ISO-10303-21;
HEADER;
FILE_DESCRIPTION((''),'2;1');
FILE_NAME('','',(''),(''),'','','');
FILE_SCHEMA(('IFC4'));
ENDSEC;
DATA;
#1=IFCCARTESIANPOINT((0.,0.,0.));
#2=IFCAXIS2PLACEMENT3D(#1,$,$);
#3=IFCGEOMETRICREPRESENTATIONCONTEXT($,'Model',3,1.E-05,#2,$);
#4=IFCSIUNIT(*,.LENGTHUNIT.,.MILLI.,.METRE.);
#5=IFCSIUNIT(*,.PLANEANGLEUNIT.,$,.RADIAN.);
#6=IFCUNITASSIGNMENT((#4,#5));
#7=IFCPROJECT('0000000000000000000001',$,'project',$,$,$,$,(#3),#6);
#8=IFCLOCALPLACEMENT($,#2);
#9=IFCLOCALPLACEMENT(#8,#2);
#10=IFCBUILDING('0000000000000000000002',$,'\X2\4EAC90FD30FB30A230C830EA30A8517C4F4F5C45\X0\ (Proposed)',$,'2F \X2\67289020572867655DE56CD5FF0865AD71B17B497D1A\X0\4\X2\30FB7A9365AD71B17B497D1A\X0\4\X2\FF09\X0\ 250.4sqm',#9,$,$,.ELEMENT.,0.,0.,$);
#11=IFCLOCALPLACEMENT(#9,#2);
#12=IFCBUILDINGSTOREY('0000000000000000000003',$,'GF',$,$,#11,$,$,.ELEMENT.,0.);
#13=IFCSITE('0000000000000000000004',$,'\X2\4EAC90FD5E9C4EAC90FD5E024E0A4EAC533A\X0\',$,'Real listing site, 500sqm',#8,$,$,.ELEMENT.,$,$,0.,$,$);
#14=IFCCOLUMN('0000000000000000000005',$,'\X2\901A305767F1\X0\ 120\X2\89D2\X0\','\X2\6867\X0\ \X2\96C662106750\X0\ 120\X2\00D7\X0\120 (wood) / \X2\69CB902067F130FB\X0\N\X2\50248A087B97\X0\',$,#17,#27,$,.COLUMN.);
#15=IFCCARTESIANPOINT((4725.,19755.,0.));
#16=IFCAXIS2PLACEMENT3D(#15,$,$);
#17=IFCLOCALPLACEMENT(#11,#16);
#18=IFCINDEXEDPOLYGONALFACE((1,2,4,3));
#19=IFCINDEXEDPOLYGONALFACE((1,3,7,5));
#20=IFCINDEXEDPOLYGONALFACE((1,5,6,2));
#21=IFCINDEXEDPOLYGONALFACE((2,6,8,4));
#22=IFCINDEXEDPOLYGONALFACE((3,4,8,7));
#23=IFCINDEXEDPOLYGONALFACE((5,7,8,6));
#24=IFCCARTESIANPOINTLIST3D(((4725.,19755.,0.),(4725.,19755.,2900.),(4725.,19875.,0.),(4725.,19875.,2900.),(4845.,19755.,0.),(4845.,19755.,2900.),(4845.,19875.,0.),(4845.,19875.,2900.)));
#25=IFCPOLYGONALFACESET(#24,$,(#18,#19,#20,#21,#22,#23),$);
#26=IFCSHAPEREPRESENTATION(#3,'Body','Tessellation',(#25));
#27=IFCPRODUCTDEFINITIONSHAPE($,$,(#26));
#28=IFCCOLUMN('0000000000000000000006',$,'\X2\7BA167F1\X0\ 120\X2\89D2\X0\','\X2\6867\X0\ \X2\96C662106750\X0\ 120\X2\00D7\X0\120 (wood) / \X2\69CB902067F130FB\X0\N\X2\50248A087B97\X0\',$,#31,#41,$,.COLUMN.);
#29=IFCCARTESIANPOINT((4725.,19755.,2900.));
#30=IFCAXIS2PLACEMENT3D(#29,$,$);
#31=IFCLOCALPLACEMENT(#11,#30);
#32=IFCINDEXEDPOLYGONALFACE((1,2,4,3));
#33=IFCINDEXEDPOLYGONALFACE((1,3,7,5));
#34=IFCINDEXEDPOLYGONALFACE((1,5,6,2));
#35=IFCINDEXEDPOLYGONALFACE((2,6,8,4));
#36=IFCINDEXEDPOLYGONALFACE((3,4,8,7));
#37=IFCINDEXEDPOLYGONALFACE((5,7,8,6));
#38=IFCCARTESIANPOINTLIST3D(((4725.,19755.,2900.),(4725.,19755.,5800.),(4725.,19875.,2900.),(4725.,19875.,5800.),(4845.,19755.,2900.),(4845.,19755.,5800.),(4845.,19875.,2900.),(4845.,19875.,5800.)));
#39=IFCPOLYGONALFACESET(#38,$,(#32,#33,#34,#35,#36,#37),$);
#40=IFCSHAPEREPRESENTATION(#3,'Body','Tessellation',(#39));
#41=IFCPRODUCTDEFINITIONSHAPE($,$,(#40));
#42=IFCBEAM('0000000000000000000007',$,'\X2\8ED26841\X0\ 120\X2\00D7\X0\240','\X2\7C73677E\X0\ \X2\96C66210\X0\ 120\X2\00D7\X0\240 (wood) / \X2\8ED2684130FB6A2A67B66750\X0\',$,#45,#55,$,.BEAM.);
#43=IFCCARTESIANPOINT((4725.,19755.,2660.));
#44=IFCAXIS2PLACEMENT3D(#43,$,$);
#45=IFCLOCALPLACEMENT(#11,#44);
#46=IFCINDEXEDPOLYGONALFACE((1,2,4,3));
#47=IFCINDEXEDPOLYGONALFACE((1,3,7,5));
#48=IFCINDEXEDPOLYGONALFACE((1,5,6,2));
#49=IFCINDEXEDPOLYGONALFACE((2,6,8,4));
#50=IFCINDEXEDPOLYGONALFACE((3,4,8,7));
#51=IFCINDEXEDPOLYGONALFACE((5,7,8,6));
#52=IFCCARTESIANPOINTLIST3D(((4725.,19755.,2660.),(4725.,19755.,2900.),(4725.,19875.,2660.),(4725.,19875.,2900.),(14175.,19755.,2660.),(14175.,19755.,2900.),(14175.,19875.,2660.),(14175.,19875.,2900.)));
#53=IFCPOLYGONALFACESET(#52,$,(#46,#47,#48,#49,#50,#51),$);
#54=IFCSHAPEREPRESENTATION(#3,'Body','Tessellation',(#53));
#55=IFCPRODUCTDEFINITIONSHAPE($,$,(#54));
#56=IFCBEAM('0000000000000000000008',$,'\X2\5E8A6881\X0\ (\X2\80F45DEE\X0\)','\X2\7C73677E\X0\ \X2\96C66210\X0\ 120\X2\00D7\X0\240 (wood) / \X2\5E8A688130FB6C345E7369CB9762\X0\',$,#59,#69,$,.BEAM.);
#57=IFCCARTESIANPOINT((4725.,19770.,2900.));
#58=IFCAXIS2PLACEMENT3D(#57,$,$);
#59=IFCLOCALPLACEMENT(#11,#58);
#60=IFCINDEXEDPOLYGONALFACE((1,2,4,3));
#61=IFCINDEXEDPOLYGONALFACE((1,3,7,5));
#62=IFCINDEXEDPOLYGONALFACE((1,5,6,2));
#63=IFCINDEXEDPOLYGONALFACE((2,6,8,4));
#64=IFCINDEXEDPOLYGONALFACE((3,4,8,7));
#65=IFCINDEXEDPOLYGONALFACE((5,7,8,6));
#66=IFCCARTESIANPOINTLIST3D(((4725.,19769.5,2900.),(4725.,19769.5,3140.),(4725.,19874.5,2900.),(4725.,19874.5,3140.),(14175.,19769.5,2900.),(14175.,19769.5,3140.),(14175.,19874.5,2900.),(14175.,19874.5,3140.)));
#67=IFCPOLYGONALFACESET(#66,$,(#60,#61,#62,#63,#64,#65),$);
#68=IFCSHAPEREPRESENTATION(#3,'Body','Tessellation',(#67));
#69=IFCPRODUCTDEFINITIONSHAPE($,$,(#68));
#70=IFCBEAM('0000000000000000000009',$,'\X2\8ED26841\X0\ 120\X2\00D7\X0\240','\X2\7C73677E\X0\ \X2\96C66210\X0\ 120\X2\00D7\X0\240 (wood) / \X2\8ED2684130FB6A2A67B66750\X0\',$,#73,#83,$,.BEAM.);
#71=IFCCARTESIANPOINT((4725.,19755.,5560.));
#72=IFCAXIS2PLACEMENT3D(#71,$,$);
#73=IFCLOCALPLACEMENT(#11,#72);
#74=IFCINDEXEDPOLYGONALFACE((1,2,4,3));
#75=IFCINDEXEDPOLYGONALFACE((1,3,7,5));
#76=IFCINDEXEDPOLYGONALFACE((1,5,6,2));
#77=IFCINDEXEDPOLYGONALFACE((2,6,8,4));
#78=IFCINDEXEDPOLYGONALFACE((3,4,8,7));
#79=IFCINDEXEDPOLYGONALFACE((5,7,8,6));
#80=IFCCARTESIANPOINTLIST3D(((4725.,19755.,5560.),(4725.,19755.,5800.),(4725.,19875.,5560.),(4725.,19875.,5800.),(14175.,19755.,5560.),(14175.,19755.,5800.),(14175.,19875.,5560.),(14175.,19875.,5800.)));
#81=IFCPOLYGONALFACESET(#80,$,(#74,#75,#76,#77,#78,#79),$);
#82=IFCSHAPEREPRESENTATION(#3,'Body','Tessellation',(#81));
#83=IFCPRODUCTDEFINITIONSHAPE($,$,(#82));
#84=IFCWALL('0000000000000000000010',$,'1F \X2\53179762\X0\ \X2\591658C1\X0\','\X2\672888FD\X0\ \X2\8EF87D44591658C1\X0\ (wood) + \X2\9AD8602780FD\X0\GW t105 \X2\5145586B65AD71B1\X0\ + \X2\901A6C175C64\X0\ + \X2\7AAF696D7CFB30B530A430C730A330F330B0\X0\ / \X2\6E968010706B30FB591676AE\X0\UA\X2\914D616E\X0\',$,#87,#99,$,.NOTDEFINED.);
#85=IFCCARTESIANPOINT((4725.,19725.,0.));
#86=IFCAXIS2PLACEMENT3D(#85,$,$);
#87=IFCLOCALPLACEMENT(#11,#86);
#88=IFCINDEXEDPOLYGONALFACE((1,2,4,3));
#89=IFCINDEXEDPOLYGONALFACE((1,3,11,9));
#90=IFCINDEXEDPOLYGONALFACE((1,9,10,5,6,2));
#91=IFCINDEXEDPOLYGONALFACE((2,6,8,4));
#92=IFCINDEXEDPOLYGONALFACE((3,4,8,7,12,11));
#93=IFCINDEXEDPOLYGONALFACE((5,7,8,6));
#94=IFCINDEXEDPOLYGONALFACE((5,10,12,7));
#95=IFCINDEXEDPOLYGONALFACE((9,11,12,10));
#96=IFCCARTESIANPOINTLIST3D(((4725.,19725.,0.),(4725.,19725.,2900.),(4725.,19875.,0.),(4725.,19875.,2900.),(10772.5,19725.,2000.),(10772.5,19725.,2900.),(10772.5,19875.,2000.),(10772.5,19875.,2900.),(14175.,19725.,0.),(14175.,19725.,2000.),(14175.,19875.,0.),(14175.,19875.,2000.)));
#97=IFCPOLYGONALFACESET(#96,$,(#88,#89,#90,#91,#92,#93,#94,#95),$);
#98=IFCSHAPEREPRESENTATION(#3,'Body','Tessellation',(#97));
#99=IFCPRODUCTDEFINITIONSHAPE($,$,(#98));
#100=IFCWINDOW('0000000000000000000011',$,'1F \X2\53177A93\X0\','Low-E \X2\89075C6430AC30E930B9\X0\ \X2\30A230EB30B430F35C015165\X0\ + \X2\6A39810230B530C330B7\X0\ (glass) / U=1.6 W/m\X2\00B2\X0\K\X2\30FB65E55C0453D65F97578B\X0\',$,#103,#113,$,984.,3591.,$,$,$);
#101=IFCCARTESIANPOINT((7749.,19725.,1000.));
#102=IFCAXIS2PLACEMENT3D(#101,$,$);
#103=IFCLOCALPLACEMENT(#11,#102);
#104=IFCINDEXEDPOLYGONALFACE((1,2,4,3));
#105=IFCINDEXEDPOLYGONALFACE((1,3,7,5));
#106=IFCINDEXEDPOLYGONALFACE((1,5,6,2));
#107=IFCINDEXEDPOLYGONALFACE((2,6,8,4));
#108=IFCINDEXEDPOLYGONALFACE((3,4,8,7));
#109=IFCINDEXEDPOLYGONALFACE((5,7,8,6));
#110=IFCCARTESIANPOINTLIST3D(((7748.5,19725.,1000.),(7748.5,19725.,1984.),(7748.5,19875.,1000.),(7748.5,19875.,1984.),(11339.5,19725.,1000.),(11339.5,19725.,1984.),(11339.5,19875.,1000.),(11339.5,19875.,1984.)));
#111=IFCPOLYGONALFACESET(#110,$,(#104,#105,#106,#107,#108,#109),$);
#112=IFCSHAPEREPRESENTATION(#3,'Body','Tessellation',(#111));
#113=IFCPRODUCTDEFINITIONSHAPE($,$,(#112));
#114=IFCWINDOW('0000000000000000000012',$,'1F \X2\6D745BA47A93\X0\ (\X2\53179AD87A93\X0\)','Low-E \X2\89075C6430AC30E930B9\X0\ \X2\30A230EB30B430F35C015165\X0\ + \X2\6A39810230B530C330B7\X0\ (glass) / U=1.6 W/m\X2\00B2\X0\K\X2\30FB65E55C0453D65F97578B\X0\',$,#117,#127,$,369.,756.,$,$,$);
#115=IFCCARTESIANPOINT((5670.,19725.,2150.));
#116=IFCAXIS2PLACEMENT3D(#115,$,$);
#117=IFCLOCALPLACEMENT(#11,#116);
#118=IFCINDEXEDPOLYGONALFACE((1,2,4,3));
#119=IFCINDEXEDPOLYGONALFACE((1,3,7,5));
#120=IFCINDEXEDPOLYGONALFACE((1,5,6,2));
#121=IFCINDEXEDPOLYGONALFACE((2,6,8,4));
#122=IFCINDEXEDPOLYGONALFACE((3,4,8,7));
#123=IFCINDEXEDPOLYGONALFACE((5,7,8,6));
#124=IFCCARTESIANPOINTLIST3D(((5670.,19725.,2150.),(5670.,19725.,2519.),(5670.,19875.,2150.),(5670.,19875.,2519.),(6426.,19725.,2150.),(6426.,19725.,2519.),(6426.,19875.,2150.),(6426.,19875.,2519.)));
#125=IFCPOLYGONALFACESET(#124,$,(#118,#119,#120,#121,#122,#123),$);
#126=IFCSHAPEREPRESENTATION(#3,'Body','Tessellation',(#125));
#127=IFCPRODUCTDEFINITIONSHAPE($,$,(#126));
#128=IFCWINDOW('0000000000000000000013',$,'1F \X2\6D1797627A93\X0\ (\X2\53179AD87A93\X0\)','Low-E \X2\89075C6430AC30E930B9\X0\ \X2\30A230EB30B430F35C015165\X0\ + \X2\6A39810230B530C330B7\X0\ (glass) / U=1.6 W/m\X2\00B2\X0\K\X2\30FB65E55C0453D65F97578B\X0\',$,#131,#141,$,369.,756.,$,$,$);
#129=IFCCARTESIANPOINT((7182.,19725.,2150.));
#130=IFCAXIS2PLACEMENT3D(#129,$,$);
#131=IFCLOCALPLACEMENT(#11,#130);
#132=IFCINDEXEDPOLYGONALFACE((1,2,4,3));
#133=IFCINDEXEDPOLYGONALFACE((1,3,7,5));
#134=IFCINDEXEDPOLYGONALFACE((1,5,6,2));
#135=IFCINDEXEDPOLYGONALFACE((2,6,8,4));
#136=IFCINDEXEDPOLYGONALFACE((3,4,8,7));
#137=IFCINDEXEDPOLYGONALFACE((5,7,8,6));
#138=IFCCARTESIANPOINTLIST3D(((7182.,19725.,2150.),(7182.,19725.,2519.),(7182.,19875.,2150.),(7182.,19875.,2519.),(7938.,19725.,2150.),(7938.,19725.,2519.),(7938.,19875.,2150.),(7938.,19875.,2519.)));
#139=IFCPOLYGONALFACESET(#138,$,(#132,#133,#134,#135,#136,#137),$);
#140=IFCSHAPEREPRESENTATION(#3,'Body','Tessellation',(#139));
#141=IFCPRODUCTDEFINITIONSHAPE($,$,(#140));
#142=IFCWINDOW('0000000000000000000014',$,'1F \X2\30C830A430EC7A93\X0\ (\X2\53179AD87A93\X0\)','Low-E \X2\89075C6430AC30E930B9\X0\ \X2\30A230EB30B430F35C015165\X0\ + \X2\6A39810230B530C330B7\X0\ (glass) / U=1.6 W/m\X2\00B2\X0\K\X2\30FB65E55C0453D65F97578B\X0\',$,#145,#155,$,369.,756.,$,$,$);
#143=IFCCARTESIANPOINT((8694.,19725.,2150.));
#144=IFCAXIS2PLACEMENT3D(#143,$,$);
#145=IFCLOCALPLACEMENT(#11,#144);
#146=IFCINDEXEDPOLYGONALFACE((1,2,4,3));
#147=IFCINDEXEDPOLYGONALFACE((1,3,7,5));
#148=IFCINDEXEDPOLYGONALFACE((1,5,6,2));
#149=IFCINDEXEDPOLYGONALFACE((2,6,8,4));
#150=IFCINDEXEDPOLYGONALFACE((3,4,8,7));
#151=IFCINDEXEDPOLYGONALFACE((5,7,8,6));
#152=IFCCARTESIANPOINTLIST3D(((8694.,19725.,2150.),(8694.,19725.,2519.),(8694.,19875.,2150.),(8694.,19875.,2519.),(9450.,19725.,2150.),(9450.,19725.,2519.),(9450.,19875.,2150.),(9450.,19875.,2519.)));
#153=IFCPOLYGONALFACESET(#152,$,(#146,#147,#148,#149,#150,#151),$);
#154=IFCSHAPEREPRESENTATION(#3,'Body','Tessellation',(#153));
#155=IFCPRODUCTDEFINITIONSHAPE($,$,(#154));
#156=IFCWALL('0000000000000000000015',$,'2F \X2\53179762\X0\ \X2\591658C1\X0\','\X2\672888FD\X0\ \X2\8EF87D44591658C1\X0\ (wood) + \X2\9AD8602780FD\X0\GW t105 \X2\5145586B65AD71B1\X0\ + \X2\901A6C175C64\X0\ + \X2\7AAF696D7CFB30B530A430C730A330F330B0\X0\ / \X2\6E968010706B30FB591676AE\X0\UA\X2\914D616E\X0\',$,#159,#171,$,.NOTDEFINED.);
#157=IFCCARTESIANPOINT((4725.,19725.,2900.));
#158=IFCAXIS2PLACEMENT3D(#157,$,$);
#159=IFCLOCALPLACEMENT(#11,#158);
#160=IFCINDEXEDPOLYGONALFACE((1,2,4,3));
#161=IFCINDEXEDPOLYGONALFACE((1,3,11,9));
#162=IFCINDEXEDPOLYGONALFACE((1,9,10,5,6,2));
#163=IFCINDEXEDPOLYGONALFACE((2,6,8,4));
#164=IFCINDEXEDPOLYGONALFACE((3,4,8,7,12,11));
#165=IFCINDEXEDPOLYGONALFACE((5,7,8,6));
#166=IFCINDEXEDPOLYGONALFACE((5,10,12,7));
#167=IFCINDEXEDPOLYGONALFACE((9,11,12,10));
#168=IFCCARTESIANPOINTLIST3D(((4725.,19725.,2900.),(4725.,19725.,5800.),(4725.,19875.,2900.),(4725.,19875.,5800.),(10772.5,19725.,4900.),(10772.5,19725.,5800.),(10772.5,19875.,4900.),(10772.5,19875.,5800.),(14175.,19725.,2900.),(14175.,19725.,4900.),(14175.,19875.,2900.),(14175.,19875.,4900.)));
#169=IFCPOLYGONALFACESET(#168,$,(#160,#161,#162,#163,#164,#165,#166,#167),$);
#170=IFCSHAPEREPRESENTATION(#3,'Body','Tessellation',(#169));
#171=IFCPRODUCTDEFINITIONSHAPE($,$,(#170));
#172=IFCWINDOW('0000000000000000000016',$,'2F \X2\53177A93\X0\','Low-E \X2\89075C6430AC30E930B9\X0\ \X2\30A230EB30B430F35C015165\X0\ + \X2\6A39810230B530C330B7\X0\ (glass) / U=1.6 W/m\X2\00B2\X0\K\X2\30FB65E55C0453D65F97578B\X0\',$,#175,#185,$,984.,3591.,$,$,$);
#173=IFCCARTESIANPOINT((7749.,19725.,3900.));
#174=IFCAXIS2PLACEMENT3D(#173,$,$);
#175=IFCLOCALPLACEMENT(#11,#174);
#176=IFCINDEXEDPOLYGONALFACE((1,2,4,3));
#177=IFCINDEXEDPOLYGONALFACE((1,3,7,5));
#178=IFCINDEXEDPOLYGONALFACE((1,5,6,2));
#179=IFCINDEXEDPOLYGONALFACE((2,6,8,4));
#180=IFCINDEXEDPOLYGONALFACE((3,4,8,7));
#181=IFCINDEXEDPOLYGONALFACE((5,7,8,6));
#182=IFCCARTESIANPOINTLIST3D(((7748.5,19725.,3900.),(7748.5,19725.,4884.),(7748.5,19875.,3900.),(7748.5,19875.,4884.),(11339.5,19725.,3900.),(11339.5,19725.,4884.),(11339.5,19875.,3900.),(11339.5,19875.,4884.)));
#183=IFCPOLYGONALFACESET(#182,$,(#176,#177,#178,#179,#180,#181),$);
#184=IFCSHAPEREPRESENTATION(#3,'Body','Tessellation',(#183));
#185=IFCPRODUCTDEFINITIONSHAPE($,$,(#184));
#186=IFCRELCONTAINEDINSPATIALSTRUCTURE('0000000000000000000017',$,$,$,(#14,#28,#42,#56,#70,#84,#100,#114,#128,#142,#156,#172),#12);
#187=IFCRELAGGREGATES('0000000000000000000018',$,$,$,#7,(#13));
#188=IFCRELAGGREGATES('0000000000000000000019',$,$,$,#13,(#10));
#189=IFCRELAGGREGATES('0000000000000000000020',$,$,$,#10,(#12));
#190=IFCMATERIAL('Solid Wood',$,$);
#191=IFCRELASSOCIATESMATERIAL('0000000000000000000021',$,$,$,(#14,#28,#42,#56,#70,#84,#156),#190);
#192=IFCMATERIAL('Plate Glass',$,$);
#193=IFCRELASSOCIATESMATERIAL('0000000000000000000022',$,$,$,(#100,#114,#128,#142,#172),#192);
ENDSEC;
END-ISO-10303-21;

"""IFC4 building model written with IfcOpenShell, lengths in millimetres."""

from ifc_helpers import new_model, si_unit, frame, frame_2d, origin, place, context, project, spatial, rectangle, extrude, material, element, fill, save


model = new_model("IFC4")

# Units and contexts
model_context = context("Model", 3, precision=1e-05, world=origin())
ifc_project = project(units=[si_unit("LENGTHUNIT", "METRE", prefix="MILLI"), si_unit("PLANEANGLEUNIT", "RADIAN")], contexts=[model_context])

# Site, building, storey
site_placement = place(None, origin())
site = spatial("IfcSite", under=ifc_project, at=site_placement, Name="京都府京都市上京区", ObjectType="Real listing site, 500sqm", CompositionType="ELEMENT", RefElevation=0.0)
building_placement = place(site_placement, origin())
building = spatial("IfcBuilding", under=site, at=building_placement, Name="京都・アトリエ兼住居 (Proposed)", ObjectType="2F 木造在来工法（断熱等級4・窓断熱等級4） 250.4sqm", CompositionType="ELEMENT", ElevationOfRefHeight=0.0, ElevationOfTerrain=0.0)
storey_placement = place(building_placement, origin())
storey = spatial("IfcBuildingStorey", under=building, at=storey_placement, Name="GF", CompositionType="ELEMENT", Elevation=0.0)

# Columns
ifc_material_1 = material(Name="Solid Wood")
column_1_placement = place(storey_placement, frame((4725.0, 19755.0, 0.0)))
element("IfcColumn", 1, at=column_1_placement, inside=storey, material=ifc_material_1, Name="通し柱 120角", Description="桧 集成材 120×120 (wood) / 構造柱・N値計算", PredefinedType="COLUMN", context=model_context, shape_type="SweptSolid", body=[
    extrude(rectangle(XDim=120.0, YDim=120.0, at=frame_2d((60.0, 60.0))), frame((4725.0, 19755.0, 0.0)), (0.0, 0.0, 1.0), 2900.0),
])
column_2_placement = place(storey_placement, frame((4725.0, 19755.0, 2900.0)))
element("IfcColumn", 2, at=column_2_placement, inside=storey, material=ifc_material_1, Name="管柱 120角", Description="桧 集成材 120×120 (wood) / 構造柱・N値計算", PredefinedType="COLUMN", context=model_context, shape_type="SweptSolid", body=[
    extrude(rectangle(XDim=120.0, YDim=120.0, at=frame_2d((60.0, 60.0))), frame((4725.0, 19755.0, 2900.0)), (0.0, 0.0, 1.0), 2900.0),
])

# Beams
beam_1_placement = place(storey_placement, frame((4725.0, 19755.0, 2660.0)))
element("IfcBeam", 3, at=beam_1_placement, inside=storey, material=ifc_material_1, Name="軒桁 120×240", Description="米松 集成 120×240 (wood) / 軒桁・横架材", PredefinedType="BEAM", context=model_context, shape_type="SweptSolid", body=[
    extrude(rectangle(XDim=9450.0, YDim=120.0, at=frame_2d((4725.0, 60.0))), frame((4725.0, 19755.0, 2660.0)), (0.0, 0.0, 1.0), 240.0),
])
beam_2_placement = place(storey_placement, frame((4725.0, 19770.0, 2900.0)))
element("IfcBeam", 4, at=beam_2_placement, inside=storey, material=ifc_material_1, Name="床梁 (胴差)", Description="米松 集成 120×240 (wood) / 床梁・水平構面", PredefinedType="BEAM", context=model_context, shape_type="SweptSolid", body=[
    extrude(rectangle(XDim=9450.0, YDim=105.0, at=frame_2d((4725.0, 52.0))), frame((4725.0, 19770.0, 2900.0)), (0.0, 0.0, 1.0), 240.0),
])
beam_3_placement = place(storey_placement, frame((4725.0, 19755.0, 5560.0)))
element("IfcBeam", 5, at=beam_3_placement, inside=storey, material=ifc_material_1, Name="軒桁 120×240", Description="米松 集成 120×240 (wood) / 軒桁・横架材", PredefinedType="BEAM", context=model_context, shape_type="SweptSolid", body=[
    extrude(rectangle(XDim=9450.0, YDim=120.0, at=frame_2d((4725.0, 60.0))), frame((4725.0, 19755.0, 5560.0)), (0.0, 0.0, 1.0), 240.0),
])

# Wall, openings, windows
wall_1_placement = place(storey_placement, frame((4725.0, 19725.0, 0.0)))
wall_1 = element("IfcWall", 6, at=wall_1_placement, inside=storey, material=ifc_material_1, Name="1F 北面 外壁", Description="木製 軸組外壁 (wood) + 高性能GW t105 充填断熱 + 通気層 + 窯業系サイディング / 準耐火・外皮UA配慮", PredefinedType="NOTDEFINED", context=model_context, shape_type="SweptSolid", body=[
    extrude(rectangle(XDim=9450.0, YDim=150.0, at=frame_2d((4725.0, 75.0))), frame((4725.0, 19725.0, 0.0)), (0.0, 0.0, 1.0), 2900.0),
])
opening_1_placement = place(storey_placement, frame((7749.0, 19725.0, 1000.0)))
opening_1 = element("IfcOpeningElement", 7, at=opening_1_placement, cuts=wall_1, PredefinedType="NOTDEFINED", context=model_context, shape_type="SweptSolid", body=[
    extrude(rectangle(XDim=3591.0, YDim=150.0, at=frame_2d((1795.0, 75.0))), frame((7749.0, 19725.0, 1000.0)), (0.0, 0.0, 1.0), 984.0),
])
opening_2_placement = place(storey_placement, frame((5670.0, 19725.0, 2150.0)))
opening_2 = element("IfcOpeningElement", 8, at=opening_2_placement, cuts=wall_1, PredefinedType="NOTDEFINED", context=model_context, shape_type="SweptSolid", body=[
    extrude(rectangle(XDim=756.0, YDim=150.0, at=frame_2d((378.0, 75.0))), frame((5670.0, 19725.0, 2150.0)), (0.0, 0.0, 1.0), 369.0),
])
opening_3_placement = place(storey_placement, frame((7182.0, 19725.0, 2150.0)))
opening_3 = element("IfcOpeningElement", 9, at=opening_3_placement, cuts=wall_1, PredefinedType="NOTDEFINED", context=model_context, shape_type="SweptSolid", body=[
    extrude(rectangle(XDim=756.0, YDim=150.0, at=frame_2d((378.0, 75.0))), frame((7182.0, 19725.0, 2150.0)), (0.0, 0.0, 1.0), 369.0),
])
opening_4_placement = place(storey_placement, frame((8694.0, 19725.0, 2150.0)))
opening_4 = element("IfcOpeningElement", 10, at=opening_4_placement, cuts=wall_1, PredefinedType="NOTDEFINED", context=model_context, shape_type="SweptSolid", body=[
    extrude(rectangle(XDim=756.0, YDim=150.0, at=frame_2d((378.0, 75.0))), frame((8694.0, 19725.0, 2150.0)), (0.0, 0.0, 1.0), 369.0),
])
ifc_material_2 = material(Name="Plate Glass")
window_1_placement = place(storey_placement, frame((7749.0, 19725.0, 1000.0)))
window_1 = element("IfcWindow", 11, at=window_1_placement, inside=storey, material=ifc_material_2, Name="1F 北窓", Description="Low-E 複層ガラス アルゴン封入 + 樹脂サッシ (glass) / U=1.6 W/m²K・日射取得型", OverallHeight=984.0, OverallWidth=3591.0, context=model_context, shape_type="SweptSolid", body=[
    extrude(rectangle(XDim=3591.0, YDim=150.0, at=frame_2d((1795.0, 75.0))), frame((7749.0, 19725.0, 1000.0)), (0.0, 0.0, 1.0), 984.0),
])
fill(opening_1, window_1)
window_2_placement = place(storey_placement, frame((5670.0, 19725.0, 2150.0)))
window_2 = element("IfcWindow", 12, at=window_2_placement, inside=storey, material=ifc_material_2, Name="1F 浴室窓 (北高窓)", Description="Low-E 複層ガラス アルゴン封入 + 樹脂サッシ (glass) / U=1.6 W/m²K・日射取得型", OverallHeight=369.0, OverallWidth=756.0, context=model_context, shape_type="SweptSolid", body=[
    extrude(rectangle(XDim=756.0, YDim=150.0, at=frame_2d((378.0, 75.0))), frame((5670.0, 19725.0, 2150.0)), (0.0, 0.0, 1.0), 369.0),
])
fill(opening_2, window_2)
window_3_placement = place(storey_placement, frame((7182.0, 19725.0, 2150.0)))
window_3 = element("IfcWindow", 13, at=window_3_placement, inside=storey, material=ifc_material_2, Name="1F 洗面窓 (北高窓)", Description="Low-E 複層ガラス アルゴン封入 + 樹脂サッシ (glass) / U=1.6 W/m²K・日射取得型", OverallHeight=369.0, OverallWidth=756.0, context=model_context, shape_type="SweptSolid", body=[
    extrude(rectangle(XDim=756.0, YDim=150.0, at=frame_2d((378.0, 75.0))), frame((7182.0, 19725.0, 2150.0)), (0.0, 0.0, 1.0), 369.0),
])
fill(opening_3, window_3)
window_4_placement = place(storey_placement, frame((8694.0, 19725.0, 2150.0)))
window_4 = element("IfcWindow", 14, at=window_4_placement, inside=storey, material=ifc_material_2, Name="1F トイレ窓 (北高窓)", Description="Low-E 複層ガラス アルゴン封入 + 樹脂サッシ (glass) / U=1.6 W/m²K・日射取得型", OverallHeight=369.0, OverallWidth=756.0, context=model_context, shape_type="SweptSolid", body=[
    extrude(rectangle(XDim=756.0, YDim=150.0, at=frame_2d((378.0, 75.0))), frame((8694.0, 19725.0, 2150.0)), (0.0, 0.0, 1.0), 369.0),
])
fill(opening_4, window_4)

# Wall, opening, window
wall_2_placement = place(storey_placement, frame((4725.0, 19725.0, 2900.0)))
wall_2 = element("IfcWall", 15, at=wall_2_placement, inside=storey, material=ifc_material_1, Name="2F 北面 外壁", Description="木製 軸組外壁 (wood) + 高性能GW t105 充填断熱 + 通気層 + 窯業系サイディング / 準耐火・外皮UA配慮", PredefinedType="NOTDEFINED", context=model_context, shape_type="SweptSolid", body=[
    extrude(rectangle(XDim=9450.0, YDim=150.0, at=frame_2d((4725.0, 75.0))), frame((4725.0, 19725.0, 2900.0)), (0.0, 0.0, 1.0), 2900.0),
])
opening_5_placement = place(storey_placement, frame((7749.0, 19725.0, 3900.0)))
opening_5 = element("IfcOpeningElement", 16, at=opening_5_placement, cuts=wall_2, PredefinedType="NOTDEFINED", context=model_context, shape_type="SweptSolid", body=[
    extrude(rectangle(XDim=3591.0, YDim=150.0, at=frame_2d((1795.0, 75.0))), frame((7749.0, 19725.0, 3900.0)), (0.0, 0.0, 1.0), 984.0),
])
window_5_placement = place(storey_placement, frame((7749.0, 19725.0, 3900.0)))
window_5 = element("IfcWindow", 17, at=window_5_placement, inside=storey, material=ifc_material_2, Name="2F 北窓", Description="Low-E 複層ガラス アルゴン封入 + 樹脂サッシ (glass) / U=1.6 W/m²K・日射取得型", OverallHeight=984.0, OverallWidth=3591.0, context=model_context, shape_type="SweptSolid", body=[
    extrude(rectangle(XDim=3591.0, YDim=150.0, at=frame_2d((1795.0, 75.0))), frame((7749.0, 19725.0, 3900.0)), (0.0, 0.0, 1.0), 984.0),
])
fill(opening_5, window_5)

save(model, "model.ifc")
